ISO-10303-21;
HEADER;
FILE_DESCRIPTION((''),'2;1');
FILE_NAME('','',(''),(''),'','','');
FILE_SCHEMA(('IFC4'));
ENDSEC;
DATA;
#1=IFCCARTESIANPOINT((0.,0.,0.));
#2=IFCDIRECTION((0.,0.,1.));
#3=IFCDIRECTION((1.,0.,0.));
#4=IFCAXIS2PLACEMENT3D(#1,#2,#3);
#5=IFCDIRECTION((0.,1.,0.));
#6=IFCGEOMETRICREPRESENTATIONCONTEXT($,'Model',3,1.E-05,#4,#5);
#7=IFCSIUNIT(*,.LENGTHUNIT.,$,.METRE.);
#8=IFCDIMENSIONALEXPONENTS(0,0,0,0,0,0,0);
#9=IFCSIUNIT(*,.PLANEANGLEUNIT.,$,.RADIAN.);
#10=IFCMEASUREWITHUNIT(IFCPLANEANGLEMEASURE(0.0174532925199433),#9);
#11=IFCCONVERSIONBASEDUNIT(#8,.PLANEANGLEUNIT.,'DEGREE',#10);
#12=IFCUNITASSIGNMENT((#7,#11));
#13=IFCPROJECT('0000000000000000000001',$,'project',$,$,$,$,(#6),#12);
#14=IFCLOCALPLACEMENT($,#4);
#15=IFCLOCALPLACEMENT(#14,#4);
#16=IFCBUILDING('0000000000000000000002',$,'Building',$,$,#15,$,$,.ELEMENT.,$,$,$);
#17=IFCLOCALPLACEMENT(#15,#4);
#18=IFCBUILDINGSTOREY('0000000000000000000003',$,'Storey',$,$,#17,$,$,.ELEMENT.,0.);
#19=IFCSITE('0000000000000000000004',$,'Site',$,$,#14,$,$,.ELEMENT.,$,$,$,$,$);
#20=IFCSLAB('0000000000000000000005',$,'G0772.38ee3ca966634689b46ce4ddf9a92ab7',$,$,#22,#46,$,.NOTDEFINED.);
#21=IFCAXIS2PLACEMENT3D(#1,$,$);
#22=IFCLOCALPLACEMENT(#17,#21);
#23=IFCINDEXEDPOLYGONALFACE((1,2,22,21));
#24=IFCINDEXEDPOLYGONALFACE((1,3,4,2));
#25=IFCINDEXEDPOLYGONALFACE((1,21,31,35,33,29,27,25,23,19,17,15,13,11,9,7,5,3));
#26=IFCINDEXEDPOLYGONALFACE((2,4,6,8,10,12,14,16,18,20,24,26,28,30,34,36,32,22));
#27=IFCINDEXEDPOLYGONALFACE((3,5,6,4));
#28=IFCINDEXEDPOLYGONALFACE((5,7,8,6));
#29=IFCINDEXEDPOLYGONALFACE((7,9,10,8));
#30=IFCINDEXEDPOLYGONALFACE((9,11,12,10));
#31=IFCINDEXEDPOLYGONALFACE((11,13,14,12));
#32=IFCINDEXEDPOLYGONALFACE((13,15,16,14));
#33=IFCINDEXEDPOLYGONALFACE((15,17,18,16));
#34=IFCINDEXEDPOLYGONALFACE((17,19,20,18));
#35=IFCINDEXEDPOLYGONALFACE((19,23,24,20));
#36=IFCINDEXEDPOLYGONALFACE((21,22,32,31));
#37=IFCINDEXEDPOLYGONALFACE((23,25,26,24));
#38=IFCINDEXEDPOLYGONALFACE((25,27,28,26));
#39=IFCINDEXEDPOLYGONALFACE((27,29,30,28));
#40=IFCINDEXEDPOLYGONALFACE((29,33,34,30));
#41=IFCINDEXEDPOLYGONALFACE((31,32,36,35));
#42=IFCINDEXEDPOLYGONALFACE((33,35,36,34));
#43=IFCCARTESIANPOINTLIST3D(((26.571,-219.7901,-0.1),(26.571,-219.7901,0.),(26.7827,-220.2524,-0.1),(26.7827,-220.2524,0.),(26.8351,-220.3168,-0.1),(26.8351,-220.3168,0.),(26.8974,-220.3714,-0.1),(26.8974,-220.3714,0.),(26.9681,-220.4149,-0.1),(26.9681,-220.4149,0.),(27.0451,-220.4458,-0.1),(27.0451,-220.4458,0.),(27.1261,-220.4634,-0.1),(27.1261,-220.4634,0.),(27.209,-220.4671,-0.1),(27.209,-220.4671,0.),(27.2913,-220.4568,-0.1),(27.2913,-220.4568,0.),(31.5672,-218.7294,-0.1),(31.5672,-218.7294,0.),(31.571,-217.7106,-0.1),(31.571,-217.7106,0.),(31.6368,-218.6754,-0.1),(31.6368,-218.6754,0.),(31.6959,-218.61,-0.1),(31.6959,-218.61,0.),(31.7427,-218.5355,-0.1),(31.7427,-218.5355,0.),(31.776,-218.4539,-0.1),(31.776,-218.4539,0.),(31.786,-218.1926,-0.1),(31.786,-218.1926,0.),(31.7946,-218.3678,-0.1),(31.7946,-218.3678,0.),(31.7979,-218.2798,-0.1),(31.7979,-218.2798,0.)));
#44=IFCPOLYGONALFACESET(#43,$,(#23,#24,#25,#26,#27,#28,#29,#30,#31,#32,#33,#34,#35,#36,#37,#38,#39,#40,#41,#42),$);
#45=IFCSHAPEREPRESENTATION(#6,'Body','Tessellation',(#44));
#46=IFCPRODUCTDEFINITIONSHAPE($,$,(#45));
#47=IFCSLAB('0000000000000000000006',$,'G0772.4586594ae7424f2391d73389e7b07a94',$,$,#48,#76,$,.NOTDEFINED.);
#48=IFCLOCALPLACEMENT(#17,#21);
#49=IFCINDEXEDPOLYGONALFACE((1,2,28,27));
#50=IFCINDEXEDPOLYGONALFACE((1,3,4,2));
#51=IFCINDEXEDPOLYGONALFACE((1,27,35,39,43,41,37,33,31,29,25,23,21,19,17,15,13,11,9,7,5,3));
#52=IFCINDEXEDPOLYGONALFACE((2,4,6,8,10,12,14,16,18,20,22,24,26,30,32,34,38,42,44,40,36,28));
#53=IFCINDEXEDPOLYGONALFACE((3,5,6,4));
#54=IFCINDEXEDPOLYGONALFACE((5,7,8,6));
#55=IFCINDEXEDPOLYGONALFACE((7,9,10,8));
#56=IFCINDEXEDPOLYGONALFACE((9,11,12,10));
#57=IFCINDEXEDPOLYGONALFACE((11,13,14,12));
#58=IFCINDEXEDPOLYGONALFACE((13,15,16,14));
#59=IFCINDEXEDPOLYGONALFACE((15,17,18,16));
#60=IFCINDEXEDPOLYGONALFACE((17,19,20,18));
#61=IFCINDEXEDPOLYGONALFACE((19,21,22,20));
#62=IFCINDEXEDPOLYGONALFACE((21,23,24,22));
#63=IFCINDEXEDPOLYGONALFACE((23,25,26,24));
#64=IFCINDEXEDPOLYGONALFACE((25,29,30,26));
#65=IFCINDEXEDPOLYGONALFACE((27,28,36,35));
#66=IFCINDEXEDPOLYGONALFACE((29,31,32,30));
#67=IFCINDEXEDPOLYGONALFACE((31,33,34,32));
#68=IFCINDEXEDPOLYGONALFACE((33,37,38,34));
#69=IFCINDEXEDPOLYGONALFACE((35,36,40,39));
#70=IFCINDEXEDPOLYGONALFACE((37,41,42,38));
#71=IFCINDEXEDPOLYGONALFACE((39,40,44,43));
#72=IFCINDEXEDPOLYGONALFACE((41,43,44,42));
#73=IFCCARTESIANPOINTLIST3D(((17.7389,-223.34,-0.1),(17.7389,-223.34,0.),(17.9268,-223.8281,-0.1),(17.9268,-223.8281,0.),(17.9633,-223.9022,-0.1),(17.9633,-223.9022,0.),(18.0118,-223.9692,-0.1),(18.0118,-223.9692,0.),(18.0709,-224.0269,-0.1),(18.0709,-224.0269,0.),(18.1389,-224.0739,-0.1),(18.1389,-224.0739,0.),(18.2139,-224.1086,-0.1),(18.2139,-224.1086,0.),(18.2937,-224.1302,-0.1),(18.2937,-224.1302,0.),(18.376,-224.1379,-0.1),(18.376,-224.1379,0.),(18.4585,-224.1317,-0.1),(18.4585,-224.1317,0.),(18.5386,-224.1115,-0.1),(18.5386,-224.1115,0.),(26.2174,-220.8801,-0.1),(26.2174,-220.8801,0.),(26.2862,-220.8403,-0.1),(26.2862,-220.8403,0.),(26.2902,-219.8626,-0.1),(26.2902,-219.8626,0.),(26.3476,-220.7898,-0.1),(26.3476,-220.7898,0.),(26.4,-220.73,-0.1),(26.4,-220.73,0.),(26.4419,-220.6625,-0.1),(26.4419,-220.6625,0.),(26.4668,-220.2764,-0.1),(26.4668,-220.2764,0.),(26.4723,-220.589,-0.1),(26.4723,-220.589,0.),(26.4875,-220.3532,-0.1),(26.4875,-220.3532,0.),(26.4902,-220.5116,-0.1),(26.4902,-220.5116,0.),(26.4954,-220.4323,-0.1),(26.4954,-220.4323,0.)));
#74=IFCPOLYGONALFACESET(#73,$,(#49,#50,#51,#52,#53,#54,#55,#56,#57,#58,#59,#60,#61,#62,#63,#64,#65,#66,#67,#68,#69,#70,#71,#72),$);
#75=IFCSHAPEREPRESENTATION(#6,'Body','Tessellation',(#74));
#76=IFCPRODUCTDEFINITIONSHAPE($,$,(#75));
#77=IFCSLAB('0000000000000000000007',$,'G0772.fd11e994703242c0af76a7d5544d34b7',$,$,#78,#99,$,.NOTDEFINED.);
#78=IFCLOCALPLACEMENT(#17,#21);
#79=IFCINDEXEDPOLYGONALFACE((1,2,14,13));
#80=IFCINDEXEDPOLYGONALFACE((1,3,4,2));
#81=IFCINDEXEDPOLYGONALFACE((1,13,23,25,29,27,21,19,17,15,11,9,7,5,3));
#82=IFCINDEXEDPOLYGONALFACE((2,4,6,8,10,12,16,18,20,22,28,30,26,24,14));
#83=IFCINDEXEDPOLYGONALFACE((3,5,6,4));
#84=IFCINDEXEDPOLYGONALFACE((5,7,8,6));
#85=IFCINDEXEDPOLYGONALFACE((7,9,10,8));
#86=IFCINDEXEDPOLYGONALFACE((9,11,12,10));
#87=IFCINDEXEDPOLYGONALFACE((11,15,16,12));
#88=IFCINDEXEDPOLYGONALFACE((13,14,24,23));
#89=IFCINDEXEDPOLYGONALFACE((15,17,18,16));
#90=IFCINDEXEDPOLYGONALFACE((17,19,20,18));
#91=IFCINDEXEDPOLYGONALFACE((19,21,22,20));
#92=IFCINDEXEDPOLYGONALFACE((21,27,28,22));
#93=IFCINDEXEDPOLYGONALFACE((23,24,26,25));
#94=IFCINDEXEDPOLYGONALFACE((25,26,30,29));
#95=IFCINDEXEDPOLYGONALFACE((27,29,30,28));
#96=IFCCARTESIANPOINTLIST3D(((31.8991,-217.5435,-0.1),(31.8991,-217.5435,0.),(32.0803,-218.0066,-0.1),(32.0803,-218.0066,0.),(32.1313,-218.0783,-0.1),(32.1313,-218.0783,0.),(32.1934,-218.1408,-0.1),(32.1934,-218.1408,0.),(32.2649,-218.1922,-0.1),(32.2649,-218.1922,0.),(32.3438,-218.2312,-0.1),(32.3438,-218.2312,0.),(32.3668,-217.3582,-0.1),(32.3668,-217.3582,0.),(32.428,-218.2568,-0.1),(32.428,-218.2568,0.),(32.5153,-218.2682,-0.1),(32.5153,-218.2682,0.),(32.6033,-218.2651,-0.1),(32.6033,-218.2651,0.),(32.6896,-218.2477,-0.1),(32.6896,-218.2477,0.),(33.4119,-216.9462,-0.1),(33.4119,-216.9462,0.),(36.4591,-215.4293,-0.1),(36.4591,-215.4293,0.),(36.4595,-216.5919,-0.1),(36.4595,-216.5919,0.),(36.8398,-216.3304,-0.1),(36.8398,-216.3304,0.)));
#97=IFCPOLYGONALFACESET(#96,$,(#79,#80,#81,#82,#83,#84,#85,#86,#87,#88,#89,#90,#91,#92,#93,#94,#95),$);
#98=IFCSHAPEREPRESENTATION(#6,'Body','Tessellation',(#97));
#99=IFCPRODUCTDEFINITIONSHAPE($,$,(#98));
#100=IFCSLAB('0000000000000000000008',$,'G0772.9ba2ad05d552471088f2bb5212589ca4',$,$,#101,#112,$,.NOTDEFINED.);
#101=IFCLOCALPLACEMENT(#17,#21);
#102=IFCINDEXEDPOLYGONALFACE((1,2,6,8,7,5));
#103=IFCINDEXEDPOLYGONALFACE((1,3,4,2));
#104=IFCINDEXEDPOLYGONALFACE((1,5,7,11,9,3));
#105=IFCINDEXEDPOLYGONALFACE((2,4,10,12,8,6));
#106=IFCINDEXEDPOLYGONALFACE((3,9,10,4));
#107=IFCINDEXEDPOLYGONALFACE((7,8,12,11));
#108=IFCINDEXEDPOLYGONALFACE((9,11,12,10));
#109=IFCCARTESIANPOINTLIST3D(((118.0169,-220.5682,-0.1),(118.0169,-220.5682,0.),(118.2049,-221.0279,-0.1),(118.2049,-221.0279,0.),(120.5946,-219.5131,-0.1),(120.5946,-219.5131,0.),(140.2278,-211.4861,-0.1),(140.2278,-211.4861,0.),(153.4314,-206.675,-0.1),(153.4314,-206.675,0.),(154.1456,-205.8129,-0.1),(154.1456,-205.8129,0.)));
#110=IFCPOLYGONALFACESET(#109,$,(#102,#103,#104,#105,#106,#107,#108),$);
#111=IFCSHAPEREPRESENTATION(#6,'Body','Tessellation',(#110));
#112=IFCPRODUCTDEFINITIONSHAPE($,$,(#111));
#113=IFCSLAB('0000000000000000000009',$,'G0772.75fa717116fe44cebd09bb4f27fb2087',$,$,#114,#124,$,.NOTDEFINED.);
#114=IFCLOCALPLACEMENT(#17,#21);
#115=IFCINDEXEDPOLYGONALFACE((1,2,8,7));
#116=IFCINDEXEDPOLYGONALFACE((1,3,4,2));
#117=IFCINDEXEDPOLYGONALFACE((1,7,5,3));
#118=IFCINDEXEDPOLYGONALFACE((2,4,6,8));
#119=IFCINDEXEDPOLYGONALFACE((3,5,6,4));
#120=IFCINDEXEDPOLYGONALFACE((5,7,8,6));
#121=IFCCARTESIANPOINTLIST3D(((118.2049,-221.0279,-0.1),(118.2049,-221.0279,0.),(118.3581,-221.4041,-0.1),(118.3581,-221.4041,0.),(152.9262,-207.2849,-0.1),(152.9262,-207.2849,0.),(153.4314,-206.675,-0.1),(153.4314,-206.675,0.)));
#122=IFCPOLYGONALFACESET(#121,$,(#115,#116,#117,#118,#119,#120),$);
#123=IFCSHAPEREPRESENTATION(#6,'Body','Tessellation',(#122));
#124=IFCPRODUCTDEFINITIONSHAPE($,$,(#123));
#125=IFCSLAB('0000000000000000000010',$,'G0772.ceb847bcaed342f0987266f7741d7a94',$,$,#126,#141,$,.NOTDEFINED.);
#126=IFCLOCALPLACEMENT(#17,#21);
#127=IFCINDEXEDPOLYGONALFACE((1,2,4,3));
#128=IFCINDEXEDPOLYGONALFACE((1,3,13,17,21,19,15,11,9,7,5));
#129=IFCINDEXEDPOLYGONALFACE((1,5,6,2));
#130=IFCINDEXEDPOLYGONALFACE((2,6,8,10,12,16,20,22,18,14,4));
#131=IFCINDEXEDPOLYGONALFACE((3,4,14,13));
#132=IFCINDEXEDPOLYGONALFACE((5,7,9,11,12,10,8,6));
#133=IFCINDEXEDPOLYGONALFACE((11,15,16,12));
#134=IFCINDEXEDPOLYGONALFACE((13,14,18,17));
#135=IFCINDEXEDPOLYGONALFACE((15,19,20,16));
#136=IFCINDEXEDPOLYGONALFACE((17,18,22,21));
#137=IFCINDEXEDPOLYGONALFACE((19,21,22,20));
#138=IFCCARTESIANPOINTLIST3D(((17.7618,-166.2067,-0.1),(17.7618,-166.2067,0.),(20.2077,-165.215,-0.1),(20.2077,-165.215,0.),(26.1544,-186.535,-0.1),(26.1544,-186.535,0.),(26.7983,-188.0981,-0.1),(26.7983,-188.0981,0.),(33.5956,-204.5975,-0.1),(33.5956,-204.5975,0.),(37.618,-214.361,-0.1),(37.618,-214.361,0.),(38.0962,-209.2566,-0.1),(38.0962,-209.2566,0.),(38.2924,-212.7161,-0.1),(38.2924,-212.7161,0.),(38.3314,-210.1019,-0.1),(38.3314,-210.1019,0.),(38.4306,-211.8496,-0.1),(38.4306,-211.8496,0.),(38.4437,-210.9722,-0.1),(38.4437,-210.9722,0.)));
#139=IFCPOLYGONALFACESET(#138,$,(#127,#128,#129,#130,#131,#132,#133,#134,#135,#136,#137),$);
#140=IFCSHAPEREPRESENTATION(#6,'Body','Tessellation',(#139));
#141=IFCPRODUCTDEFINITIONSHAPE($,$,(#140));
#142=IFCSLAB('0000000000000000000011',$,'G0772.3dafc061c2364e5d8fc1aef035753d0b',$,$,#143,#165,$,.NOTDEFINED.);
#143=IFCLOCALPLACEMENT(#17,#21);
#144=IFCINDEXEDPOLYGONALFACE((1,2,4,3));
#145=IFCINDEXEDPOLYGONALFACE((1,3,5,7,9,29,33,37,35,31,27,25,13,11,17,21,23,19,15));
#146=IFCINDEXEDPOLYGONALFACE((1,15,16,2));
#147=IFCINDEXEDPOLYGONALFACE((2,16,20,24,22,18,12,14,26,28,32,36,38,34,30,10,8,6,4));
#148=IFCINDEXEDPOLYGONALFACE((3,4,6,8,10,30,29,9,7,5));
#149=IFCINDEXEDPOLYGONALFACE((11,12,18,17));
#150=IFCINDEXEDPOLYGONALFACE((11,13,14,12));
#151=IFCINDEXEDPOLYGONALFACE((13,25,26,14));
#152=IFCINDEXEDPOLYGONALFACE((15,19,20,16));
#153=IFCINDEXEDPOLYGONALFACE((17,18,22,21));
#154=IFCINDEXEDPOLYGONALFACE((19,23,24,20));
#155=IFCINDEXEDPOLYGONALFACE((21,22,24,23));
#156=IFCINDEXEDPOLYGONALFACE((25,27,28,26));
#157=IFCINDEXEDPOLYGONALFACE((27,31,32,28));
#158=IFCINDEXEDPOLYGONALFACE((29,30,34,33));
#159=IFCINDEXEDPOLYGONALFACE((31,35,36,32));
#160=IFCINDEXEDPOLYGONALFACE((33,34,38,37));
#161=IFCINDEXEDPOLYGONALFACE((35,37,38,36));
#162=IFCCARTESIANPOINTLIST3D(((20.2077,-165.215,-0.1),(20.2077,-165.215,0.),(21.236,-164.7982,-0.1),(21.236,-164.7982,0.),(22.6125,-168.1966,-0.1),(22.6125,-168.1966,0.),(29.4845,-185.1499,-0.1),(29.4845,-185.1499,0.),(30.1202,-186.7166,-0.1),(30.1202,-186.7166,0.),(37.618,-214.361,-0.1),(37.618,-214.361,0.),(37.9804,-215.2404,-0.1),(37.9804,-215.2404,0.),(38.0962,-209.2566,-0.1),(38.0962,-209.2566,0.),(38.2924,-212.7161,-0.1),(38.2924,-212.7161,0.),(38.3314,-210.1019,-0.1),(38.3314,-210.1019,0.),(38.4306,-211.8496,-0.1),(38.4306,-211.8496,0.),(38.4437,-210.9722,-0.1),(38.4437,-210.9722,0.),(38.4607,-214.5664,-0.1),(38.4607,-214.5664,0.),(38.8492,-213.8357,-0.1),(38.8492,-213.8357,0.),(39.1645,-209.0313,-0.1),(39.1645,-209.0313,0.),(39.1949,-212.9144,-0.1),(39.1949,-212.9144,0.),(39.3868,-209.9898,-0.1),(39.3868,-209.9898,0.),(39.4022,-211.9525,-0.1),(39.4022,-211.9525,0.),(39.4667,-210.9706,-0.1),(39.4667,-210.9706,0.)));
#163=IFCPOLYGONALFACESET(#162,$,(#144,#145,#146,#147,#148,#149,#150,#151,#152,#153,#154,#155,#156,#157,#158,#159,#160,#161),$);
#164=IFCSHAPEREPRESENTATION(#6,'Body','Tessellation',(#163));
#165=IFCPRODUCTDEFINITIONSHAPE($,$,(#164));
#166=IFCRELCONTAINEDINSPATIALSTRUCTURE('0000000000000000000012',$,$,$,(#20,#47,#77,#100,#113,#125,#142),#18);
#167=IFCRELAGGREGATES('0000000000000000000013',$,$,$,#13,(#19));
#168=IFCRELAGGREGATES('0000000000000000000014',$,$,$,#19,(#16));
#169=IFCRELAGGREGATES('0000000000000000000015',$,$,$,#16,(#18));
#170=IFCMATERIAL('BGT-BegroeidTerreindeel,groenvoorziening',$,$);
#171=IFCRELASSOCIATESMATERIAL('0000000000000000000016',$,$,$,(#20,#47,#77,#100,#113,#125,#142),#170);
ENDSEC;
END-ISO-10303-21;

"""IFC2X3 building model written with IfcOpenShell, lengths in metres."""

from ifc_helpers import new_model, entity, si_unit, converted_unit, direction, frame, origin_with_axes, place, context, project, spatial, polyline, outline, extrude, material, element, save


model = new_model("IFC2X3")

# Units and contexts
model_context = context("Model", 3, precision=1e-05, world=origin_with_axes(), true_north=direction((0.0, 1.0, 0.0)))
ifc_project = project(units=[si_unit("LENGTHUNIT", "METRE"), converted_unit("PLANEANGLEUNIT", "DEGREE", entity("IfcPlaneAngleMeasure", 0.0174532925199433), si_unit("PLANEANGLEUNIT", "RADIAN"), dimensions=[0, 0, 0, 0, 0, 0, 0])], contexts=[model_context])

# Site, building, storey
site_placement = place(None, origin_with_axes())
site = spatial("IfcSite", under=ifc_project, at=site_placement, Name="Site", CompositionType="ELEMENT")
building_placement = place(site_placement, origin_with_axes())
building = spatial("IfcBuilding", under=site, at=building_placement, Name="Building", CompositionType="ELEMENT")
storey_placement = place(building_placement, origin_with_axes())
storey = spatial("IfcBuildingStorey", under=building, at=storey_placement, Name="Storey", CompositionType="ELEMENT", Elevation=0.0)

# Slabs
ifc_material_1 = material(Name="BGT-BegroeidTerreindeel,groenvoorziening")
slab_1_placement = place(storey_placement, frame((0.0, 0.0, -0.1), z_axis=(0.0, 0.0, 1.0), x_axis=(1.0, 0.0, 0.0)))
element("IfcSlab", 1, at=slab_1_placement, inside=storey, material=ifc_material_1, Name="G0772.38ee3ca966634689b46ce4ddf9a92ab7", PredefinedType="NOTDEFINED", context=model_context, shape_type="SweptSolid", body=[
    extrude(outline(polyline([(27.2913, -220.4568), (27.209, -220.4671), (27.1261, -220.4634), (27.0451, -220.4458), (26.9681, -220.4149), (26.8974, -220.3714), (26.8351, -220.3168), (26.7827, -220.2524), (26.571, -219.7901), (31.571, -217.7106), (31.786, -218.1926), (31.7979, -218.2798), (31.7946, -218.3678), (31.776, -218.4539), (31.7427, -218.5355), (31.6959, -218.61), (31.6368, -218.6754), (31.5672, -218.7294), (27.2913, -220.4568)])), origin_with_axes(), (0.0, 0.0, 1.0), 0.1),
])
slab_2_placement = place(storey_placement, frame((0.0, 0.0, -0.1), z_axis=(0.0, 0.0, 1.0), x_axis=(1.0, 0.0, 0.0)))
element("IfcSlab", 2, at=slab_2_placement, inside=storey, material=ifc_material_1, Name="G0772.4586594ae7424f2391d73389e7b07a94", PredefinedType="NOTDEFINED", context=model_context, shape_type="SweptSolid", body=[
    extrude(outline(polyline([(26.4875, -220.3532), (26.4954, -220.4323), (26.4902, -220.5116), (26.4723, -220.589), (26.4419, -220.6625), (26.4, -220.73), (26.3476, -220.7898), (26.2862, -220.8403), (26.2174, -220.8801), (18.5386, -224.1115), (18.4585, -224.1317), (18.376, -224.1379), (18.2937, -224.1302), (18.2139, -224.1086), (18.1389, -224.0739), (18.0709, -224.0269), (18.0118, -223.9692), (17.9633, -223.9022), (17.9268, -223.8281), (17.7389, -223.34), (26.2902, -219.8626), (26.4668, -220.2764), (26.4875, -220.3532)])), origin_with_axes(), (0.0, 0.0, 1.0), 0.1),
])
slab_3_placement = place(storey_placement, frame((0.0, 0.0, -0.1), z_axis=(0.0, 0.0, 1.0), x_axis=(1.0, 0.0, 0.0)))
element("IfcSlab", 3, at=slab_3_placement, inside=storey, material=ifc_material_1, Name="G0772.fd11e994703242c0af76a7d5544d34b7", PredefinedType="NOTDEFINED", context=model_context, shape_type="SweptSolid", body=[
    extrude(outline(polyline([(31.8991, -217.5435), (32.3668, -217.3582), (33.4119, -216.9462), (36.4591, -215.4293), (36.8398, -216.3304), (36.4595, -216.5919), (32.6896, -218.2477), (32.6033, -218.2651), (32.5153, -218.2682), (32.428, -218.2568), (32.3438, -218.2312), (32.2649, -218.1922), (32.1934, -218.1408), (32.1313, -218.0783), (32.0803, -218.0066), (31.8991, -217.5435)])), origin_with_axes(), (0.0, 0.0, 1.0), 0.1),
])
slab_4_placement = place(storey_placement, frame((0.0, 0.0, -0.1), z_axis=(0.0, 0.0, 1.0), x_axis=(1.0, 0.0, 0.0)))
element("IfcSlab", 4, at=slab_4_placement, inside=storey, material=ifc_material_1, Name="G0772.9ba2ad05d552471088f2bb5212589ca4", PredefinedType="NOTDEFINED", context=model_context, shape_type="SweptSolid", body=[
    extrude(outline(polyline([(118.2049, -221.0279), (118.0169, -220.5682), (120.5946, -219.5131), (140.2278, -211.4861), (154.1456, -205.8129), (153.4314, -206.675), (118.2049, -221.0279)])), origin_with_axes(), (0.0, 0.0, 1.0), 0.1),
])
slab_5_placement = place(storey_placement, frame((0.0, 0.0, -0.1), z_axis=(0.0, 0.0, 1.0), x_axis=(1.0, 0.0, 0.0)))
element("IfcSlab", 5, at=slab_5_placement, inside=storey, material=ifc_material_1, Name="G0772.75fa717116fe44cebd09bb4f27fb2087", PredefinedType="NOTDEFINED", context=model_context, shape_type="SweptSolid", body=[
    extrude(outline(polyline([(118.3581, -221.4041), (118.2049, -221.0279), (153.4314, -206.675), (152.9262, -207.2849), (118.3581, -221.4041)])), origin_with_axes(), (0.0, 0.0, 1.0), 0.1),
])
slab_6_placement = place(storey_placement, frame((0.0, 0.0, -0.1), z_axis=(0.0, 0.0, 1.0), x_axis=(1.0, 0.0, 0.0)))
element("IfcSlab", 6, at=slab_6_placement, inside=storey, material=ifc_material_1, Name="G0772.ceb847bcaed342f0987266f7741d7a94", PredefinedType="NOTDEFINED", context=model_context, shape_type="SweptSolid", body=[
    extrude(outline(polyline([(38.0962, -209.2566), (38.3314, -210.1019), (38.4437, -210.9722), (38.4306, -211.8496), (38.2924, -212.7161), (37.618, -214.361), (33.5956, -204.5975), (26.7983, -188.0981), (26.1544, -186.535), (17.7618, -166.2067), (20.2077, -165.215), (38.0962, -209.2566)])), origin_with_axes(), (0.0, 0.0, 1.0), 0.1),
])
slab_7_placement = place(storey_placement, frame((0.0, 0.0, -0.1), z_axis=(0.0, 0.0, 1.0), x_axis=(1.0, 0.0, 0.0)))
element("IfcSlab", 7, at=slab_7_placement, inside=storey, material=ifc_material_1, Name="G0772.3dafc061c2364e5d8fc1aef035753d0b", PredefinedType="NOTDEFINED", context=model_context, shape_type="SweptSolid", body=[
    extrude(outline(polyline([(29.4845, -185.1499), (30.1202, -186.7166), (39.1645, -209.0313), (39.3868, -209.9898), (39.4667, -210.9706), (39.4022, -211.9525), (39.1949, -212.9144), (38.8492, -213.8357), (38.4607, -214.5664), (37.9804, -215.2404), (37.618, -214.361), (38.2924, -212.7161), (38.4306, -211.8496), (38.4437, -210.9722), (38.3314, -210.1019), (38.0962, -209.2566), (20.2077, -165.215), (21.236, -164.7982), (22.6125, -168.1966), (29.4845, -185.1499)])), origin_with_axes(), (0.0, 0.0, 1.0), 0.1),
])

save(model, "model.ifc")
